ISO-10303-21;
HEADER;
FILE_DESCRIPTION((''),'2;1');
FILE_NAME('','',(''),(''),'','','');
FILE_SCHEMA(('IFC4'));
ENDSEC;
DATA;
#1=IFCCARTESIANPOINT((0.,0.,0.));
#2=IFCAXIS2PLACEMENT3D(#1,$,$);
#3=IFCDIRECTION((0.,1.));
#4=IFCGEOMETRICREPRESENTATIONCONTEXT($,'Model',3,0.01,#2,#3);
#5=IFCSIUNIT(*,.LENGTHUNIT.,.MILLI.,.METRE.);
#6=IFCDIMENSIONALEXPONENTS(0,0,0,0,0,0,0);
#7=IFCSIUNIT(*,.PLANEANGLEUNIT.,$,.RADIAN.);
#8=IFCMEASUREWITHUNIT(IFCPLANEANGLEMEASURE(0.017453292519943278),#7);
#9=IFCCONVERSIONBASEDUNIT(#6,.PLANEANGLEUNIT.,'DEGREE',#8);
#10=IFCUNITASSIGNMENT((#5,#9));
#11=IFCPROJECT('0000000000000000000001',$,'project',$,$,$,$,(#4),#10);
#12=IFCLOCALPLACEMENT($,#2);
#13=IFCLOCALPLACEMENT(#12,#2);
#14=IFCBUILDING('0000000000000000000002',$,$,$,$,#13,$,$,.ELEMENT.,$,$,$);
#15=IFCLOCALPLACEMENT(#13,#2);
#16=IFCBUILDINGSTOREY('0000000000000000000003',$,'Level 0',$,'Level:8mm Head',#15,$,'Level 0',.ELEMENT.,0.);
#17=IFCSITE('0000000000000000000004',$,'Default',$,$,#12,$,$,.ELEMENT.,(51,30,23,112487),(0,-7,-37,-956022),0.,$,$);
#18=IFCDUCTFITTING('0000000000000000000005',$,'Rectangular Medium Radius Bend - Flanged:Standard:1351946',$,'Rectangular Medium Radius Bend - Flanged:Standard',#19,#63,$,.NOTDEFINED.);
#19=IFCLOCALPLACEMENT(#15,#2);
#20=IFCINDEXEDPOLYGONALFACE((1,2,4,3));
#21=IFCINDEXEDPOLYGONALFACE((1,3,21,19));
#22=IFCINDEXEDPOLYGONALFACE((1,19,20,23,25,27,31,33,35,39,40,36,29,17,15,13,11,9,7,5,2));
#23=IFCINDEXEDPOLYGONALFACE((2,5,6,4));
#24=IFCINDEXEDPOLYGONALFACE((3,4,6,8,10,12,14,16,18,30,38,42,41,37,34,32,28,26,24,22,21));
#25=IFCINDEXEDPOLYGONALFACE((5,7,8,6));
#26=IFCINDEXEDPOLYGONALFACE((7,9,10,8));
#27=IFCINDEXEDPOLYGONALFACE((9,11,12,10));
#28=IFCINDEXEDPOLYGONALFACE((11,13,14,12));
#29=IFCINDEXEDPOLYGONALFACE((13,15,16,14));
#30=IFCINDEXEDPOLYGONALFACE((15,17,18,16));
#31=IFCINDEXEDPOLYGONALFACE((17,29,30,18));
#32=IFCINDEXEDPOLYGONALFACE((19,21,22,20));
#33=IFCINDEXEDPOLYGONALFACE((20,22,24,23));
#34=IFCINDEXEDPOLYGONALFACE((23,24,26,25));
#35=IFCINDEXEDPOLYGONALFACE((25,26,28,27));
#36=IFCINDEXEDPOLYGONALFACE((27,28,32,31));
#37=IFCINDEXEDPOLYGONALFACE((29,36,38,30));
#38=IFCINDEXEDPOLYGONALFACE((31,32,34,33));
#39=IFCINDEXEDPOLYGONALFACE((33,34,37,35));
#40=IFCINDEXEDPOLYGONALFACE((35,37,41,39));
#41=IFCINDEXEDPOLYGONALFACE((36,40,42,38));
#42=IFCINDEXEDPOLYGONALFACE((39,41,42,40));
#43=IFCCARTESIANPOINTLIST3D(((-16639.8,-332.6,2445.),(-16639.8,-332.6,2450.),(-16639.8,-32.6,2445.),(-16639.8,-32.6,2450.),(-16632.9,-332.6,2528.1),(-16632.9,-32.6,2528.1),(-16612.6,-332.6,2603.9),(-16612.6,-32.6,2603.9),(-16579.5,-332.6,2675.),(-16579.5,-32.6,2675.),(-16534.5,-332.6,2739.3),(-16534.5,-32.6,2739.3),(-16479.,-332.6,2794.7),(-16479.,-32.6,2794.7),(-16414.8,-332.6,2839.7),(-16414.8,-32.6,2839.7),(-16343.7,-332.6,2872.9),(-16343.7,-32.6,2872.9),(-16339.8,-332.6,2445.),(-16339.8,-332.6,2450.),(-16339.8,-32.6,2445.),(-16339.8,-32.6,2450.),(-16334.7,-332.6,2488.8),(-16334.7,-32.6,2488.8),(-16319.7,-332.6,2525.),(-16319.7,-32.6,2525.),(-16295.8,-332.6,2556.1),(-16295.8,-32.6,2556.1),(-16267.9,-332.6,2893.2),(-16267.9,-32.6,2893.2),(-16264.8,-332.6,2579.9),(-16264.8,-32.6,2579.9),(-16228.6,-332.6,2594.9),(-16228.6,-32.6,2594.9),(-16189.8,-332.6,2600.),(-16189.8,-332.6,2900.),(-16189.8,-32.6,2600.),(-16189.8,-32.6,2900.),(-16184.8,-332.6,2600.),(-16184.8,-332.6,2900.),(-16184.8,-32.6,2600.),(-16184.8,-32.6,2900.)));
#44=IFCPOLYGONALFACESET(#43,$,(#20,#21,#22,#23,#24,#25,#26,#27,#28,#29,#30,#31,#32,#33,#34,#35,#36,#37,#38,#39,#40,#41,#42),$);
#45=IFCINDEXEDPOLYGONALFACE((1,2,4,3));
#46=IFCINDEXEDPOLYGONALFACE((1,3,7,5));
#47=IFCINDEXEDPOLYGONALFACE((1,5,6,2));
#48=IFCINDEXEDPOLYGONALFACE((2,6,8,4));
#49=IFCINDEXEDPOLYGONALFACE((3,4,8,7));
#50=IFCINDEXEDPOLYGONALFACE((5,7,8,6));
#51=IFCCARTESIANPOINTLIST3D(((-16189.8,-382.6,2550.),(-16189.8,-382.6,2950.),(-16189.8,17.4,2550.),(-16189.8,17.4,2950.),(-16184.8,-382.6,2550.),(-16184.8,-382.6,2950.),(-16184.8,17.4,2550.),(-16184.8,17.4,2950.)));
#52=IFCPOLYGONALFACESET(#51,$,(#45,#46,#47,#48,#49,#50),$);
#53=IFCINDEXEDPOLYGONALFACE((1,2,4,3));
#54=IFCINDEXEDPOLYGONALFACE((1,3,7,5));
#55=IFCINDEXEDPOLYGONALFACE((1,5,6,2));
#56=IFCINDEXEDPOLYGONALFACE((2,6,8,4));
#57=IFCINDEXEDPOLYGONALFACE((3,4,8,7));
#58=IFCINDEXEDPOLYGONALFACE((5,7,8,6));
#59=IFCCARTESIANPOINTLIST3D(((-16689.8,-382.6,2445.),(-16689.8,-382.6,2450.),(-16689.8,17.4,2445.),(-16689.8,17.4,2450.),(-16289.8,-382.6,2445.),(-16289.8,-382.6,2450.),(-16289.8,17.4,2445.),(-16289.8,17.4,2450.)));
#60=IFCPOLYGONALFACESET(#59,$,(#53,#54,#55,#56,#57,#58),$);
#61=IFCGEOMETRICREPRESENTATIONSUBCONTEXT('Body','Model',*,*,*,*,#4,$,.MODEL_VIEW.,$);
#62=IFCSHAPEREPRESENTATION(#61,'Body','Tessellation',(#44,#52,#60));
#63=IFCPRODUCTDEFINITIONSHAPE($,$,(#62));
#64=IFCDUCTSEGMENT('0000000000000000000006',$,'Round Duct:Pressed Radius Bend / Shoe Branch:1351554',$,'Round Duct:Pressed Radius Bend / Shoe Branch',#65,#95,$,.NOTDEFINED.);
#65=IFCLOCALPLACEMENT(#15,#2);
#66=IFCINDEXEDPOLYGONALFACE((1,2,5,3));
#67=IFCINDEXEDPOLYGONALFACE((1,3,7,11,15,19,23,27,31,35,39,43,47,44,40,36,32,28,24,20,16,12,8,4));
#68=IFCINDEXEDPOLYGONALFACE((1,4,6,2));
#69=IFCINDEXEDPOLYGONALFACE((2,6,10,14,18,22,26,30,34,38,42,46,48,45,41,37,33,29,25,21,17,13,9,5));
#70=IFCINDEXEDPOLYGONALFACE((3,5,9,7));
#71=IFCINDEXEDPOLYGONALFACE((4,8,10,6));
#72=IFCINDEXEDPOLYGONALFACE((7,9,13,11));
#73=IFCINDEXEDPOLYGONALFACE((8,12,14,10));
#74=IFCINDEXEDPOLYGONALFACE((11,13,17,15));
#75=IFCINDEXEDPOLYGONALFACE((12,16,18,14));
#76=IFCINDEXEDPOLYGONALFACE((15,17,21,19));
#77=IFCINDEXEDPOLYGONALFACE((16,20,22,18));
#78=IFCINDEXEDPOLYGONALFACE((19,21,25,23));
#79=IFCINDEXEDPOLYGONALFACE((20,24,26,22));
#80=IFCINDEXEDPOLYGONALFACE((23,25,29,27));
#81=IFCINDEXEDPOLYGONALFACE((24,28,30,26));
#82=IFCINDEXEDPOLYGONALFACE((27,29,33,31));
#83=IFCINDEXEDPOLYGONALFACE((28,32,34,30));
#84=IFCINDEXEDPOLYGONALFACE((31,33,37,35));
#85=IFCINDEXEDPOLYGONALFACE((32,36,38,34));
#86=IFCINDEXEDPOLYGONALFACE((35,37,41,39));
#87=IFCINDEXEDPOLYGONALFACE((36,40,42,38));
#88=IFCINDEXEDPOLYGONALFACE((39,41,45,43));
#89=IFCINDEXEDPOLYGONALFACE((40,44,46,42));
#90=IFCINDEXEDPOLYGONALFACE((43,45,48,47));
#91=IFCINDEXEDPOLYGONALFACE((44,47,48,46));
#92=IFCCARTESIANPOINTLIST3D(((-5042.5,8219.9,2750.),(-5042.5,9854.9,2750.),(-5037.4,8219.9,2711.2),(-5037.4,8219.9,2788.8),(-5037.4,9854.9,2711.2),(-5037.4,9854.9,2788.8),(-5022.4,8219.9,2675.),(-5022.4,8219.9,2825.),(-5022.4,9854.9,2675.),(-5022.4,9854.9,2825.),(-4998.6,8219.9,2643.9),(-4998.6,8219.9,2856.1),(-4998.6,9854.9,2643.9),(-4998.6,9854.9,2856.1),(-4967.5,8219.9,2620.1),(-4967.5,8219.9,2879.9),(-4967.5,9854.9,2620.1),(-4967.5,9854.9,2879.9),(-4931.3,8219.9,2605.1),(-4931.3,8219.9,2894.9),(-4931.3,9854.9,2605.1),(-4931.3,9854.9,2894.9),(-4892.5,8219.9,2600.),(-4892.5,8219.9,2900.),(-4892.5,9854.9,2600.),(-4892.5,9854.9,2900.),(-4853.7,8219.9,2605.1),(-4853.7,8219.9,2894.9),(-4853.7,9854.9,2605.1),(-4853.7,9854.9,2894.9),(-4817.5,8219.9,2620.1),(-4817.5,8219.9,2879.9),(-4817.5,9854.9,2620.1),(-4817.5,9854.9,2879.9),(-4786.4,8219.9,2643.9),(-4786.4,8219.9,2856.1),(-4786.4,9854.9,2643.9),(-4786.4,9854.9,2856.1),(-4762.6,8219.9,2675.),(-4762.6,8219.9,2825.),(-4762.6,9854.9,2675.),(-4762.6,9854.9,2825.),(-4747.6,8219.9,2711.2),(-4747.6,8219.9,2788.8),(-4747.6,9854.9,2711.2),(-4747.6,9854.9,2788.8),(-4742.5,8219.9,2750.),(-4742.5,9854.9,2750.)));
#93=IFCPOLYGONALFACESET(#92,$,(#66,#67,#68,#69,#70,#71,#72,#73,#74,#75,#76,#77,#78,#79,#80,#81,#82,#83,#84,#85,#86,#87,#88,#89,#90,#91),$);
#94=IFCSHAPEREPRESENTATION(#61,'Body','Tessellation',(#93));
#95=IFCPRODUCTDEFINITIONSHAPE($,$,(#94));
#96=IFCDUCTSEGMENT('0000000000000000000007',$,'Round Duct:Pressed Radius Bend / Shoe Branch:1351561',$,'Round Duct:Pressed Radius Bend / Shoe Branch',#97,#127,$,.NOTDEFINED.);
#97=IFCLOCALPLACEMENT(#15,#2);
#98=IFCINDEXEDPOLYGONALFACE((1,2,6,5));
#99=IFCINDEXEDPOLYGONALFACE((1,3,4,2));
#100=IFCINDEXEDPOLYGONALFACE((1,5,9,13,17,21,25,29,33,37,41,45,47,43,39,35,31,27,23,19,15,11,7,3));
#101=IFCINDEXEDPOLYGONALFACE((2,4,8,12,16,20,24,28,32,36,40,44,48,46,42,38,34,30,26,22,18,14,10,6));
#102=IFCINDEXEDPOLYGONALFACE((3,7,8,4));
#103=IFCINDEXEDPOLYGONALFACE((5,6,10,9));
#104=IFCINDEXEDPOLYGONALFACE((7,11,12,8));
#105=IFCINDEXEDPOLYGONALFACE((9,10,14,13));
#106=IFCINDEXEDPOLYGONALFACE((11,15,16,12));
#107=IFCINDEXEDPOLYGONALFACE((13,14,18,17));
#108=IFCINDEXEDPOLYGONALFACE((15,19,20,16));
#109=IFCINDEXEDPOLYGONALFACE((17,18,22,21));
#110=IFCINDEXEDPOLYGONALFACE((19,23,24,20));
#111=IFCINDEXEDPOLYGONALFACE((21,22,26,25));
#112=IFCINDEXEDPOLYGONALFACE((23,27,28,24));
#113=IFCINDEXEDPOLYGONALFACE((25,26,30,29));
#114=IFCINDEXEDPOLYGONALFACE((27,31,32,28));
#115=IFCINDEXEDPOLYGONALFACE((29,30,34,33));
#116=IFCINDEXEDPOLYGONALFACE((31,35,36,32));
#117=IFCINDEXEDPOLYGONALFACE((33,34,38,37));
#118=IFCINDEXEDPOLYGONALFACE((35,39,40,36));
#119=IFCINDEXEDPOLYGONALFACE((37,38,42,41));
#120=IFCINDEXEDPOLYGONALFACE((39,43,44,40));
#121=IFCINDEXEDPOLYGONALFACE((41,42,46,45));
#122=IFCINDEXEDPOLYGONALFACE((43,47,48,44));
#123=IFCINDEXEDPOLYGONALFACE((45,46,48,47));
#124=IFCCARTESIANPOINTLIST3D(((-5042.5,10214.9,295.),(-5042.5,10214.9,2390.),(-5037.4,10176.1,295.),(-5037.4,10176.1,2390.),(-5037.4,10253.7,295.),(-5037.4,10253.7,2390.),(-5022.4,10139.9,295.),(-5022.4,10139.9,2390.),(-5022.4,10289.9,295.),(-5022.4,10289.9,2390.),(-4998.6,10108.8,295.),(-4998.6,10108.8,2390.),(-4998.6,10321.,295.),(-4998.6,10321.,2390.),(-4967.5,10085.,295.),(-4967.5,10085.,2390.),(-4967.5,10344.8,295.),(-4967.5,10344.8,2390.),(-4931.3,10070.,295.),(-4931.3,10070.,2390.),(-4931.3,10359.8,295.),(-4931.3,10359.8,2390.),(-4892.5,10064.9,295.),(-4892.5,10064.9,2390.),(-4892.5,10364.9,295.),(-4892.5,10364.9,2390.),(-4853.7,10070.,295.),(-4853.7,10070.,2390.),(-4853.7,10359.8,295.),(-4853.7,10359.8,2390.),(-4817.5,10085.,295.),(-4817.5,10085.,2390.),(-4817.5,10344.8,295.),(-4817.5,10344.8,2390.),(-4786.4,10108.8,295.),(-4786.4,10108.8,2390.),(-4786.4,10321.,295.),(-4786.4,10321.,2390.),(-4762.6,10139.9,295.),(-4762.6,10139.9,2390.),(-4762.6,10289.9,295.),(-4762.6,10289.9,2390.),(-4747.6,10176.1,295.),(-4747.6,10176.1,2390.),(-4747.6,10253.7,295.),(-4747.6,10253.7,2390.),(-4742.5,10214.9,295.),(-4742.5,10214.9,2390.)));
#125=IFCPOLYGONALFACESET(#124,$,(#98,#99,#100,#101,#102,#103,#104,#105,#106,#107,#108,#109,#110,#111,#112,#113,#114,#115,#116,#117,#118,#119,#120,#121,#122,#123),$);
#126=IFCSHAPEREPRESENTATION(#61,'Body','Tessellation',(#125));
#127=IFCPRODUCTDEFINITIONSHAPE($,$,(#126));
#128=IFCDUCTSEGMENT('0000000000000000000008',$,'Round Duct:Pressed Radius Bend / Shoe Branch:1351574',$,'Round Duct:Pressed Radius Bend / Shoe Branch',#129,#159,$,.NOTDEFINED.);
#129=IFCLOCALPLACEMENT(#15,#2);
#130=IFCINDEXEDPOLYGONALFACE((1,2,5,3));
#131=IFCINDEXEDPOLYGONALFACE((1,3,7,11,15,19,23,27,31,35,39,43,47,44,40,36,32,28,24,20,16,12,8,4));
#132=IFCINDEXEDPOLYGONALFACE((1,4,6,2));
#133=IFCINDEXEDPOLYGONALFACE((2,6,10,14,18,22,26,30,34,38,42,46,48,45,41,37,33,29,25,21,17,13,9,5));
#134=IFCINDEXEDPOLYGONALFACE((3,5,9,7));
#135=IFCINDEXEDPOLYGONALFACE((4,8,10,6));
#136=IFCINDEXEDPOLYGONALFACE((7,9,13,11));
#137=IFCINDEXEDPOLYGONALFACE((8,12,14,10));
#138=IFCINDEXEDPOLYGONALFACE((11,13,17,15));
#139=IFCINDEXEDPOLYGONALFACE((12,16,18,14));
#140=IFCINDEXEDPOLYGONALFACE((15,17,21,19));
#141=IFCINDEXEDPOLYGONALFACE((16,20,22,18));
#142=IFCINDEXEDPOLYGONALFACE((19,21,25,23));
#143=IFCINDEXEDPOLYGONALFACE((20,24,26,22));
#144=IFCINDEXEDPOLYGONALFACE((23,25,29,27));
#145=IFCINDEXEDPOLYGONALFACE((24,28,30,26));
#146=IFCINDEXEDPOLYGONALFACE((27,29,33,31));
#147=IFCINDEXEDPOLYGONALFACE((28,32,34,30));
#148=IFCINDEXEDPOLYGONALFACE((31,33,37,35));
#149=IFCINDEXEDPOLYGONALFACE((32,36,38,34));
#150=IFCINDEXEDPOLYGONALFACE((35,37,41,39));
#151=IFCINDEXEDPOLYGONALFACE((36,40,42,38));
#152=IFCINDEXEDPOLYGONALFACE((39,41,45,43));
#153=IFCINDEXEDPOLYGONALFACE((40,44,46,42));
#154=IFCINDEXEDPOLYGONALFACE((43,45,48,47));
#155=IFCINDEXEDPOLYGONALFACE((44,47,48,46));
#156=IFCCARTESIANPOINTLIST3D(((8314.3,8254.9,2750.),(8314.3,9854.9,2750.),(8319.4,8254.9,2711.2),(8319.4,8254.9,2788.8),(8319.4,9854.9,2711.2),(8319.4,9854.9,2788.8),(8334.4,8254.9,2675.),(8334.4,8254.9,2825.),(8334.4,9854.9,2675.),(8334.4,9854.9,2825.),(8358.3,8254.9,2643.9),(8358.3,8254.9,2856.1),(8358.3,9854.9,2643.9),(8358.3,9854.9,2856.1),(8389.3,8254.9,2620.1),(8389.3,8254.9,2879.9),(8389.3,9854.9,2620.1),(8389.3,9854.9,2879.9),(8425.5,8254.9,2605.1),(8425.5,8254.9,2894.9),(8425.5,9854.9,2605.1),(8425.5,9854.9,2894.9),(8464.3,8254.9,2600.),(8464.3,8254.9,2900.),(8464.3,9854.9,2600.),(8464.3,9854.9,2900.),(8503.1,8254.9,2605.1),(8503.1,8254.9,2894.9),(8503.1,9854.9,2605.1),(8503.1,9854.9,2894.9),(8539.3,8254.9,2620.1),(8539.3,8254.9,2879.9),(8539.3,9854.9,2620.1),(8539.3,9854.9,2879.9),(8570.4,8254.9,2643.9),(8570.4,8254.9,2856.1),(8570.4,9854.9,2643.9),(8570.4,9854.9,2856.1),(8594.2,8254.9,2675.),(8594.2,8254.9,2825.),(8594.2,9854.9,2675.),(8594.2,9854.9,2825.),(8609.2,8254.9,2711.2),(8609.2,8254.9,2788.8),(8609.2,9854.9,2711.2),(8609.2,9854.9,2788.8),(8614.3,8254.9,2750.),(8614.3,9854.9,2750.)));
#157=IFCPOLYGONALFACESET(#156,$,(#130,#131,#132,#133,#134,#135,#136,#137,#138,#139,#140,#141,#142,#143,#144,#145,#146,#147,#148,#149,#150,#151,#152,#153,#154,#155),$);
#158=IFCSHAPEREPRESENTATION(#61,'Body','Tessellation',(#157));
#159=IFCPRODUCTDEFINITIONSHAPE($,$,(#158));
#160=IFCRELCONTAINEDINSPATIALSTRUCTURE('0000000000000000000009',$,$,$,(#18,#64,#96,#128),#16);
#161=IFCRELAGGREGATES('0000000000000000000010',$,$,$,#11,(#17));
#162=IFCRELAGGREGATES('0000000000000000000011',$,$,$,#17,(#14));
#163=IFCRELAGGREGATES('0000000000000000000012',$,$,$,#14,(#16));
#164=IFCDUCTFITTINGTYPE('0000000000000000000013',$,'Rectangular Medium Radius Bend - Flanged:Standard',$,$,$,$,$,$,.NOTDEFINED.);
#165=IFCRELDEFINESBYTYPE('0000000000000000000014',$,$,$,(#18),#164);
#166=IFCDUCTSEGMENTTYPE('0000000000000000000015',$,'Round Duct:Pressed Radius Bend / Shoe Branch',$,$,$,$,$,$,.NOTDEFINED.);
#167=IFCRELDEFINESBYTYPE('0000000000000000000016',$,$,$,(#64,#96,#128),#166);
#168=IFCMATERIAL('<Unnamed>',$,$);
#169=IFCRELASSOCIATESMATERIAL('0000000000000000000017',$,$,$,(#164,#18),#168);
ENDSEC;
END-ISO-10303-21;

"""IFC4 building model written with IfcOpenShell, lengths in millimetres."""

from ifc_helpers import new_model, entity, si_unit, converted_unit, direction, frame, origin, place, context, subcontext, project, spatial, line, arc, indexed_curve, outline, extrude, source, transform, mapped, material, type_object, type_shapes, element, save


model = new_model("IFC4")

# Units and contexts
model_context = context("Model", 3, precision=0.01, world=origin(), true_north=direction((0.0, 1.0)))
body_context = subcontext(model_context, "Body", "Model", "MODEL_VIEW")
ifc_project = project(units=[si_unit("LENGTHUNIT", "METRE", prefix="MILLI"), converted_unit("PLANEANGLEUNIT", "DEGREE", entity("IfcPlaneAngleMeasure", 0.017453292519943278), si_unit("PLANEANGLEUNIT", "RADIAN"), dimensions=[0, 0, 0, 0, 0, 0, 0])], contexts=[model_context])

# Site, building, storey
site_placement = place(None, origin())
site = spatial("IfcSite", under=ifc_project, at=site_placement, Name="Default", CompositionType="ELEMENT", RefLatitude=(51, 30, 23, 112487), RefLongitude=(0, -7, -37, -956022), RefElevation=0.0)
building_placement = place(site_placement, origin())
building = spatial("IfcBuilding", under=site, at=building_placement, CompositionType="ELEMENT")
storey_placement = place(building_placement, origin())
storey = spatial("IfcBuildingStorey", under=building, at=storey_placement, Name="Level 0", ObjectType="Level:8mm Head", LongName="Level 0", CompositionType="ELEMENT", Elevation=0.0)

# Duct fitting
ifc_material = material(Name="<Unnamed>")
duct_fitting_type = type_object("IfcDuctFittingType", Name="Rectangular Medium Radius Bend - Flanged:Standard", PredefinedType="NOTDEFINED", material=ifc_material)
shared_shape = source(origin(), body_context, "Body", "SweptSolid", [
    extrude(outline(indexed_curve([(-153.8, -301.2), (-148.7, -301.2), (169.4, -169.4), (301.3, 148.7), (301.3, 153.7), (1.3, 153.7), (1.3, 148.8), (-42.7, 42.7), (-148.7, -1.2), (-153.8, -1.2)], segments=[line(1, 2), arc(2, 3, 4), line(4, 5, 6, 7), arc(7, 8, 9), line(9, 10, 1)], self_intersect=False)), frame((-151.2, 151.2, -150.0)), (0.0, 0.0, 1.0), 300.0),
    extrude(outline(indexed_curve([(-2.5, -200.0), (2.5, -200.0), (2.5, 200.0), (-2.5, 200.0), (-2.5, -200.0)], self_intersect=False)), frame((0.0, 302.5, -200.0), z_axis=(0.0, 0.0, 1.0), x_axis=(0.0, 1.0, 0.0)), (0.0, 0.0, 1.0), 400.0),
    extrude(outline(indexed_curve([(-2.5, -200.0), (2.5, -200.0), (2.5, 200.0), (-2.5, 200.0), (-2.5, -200.0)], self_intersect=False)), frame((-302.5, 0.0, -200.0)), (0.0, 0.0, 1.0), 400.0),
])
type_shapes(duct_fitting_type, [shared_shape])
for number, where, z_axis, x_axis, name in (
    (1, (-16489.8, -182.6, 2750.0), (0.0, 1.0, 0.0), (0.0, 0.0, 1.0), "Rectangular Medium Radius Bend - Flanged:Standard:1351946"),
):
    element("IfcDuctFitting", number, at=place(storey_placement, frame(where, z_axis=z_axis, x_axis=x_axis)), inside=storey, type_object=duct_fitting_type, material=ifc_material, Name=name, ObjectType="Rectangular Medium Radius Bend - Flanged:Standard", PredefinedType="NOTDEFINED", context=body_context, shape_type="MappedRepresentation", body=[
        mapped(shared_shape, transform((0.0, 0.0, 0.0), scale=1.0)),
    ])

# Duct segments
duct_segment_type_1 = type_object("IfcDuctSegmentType", Name="Round Duct:Pressed Radius Bend / Shoe Branch", PredefinedType="NOTDEFINED")
duct_segment_1_placement = place(storey_placement, origin())
element("IfcDuctSegment", 2, at=duct_segment_1_placement, inside=storey, type_object=duct_segment_type_1, Name="Round Duct:Pressed Radius Bend / Shoe Branch:1351554", ObjectType="Round Duct:Pressed Radius Bend / Shoe Branch", PredefinedType="NOTDEFINED", context=body_context, shape_type="SweptSolid", body=[
    extrude(outline(indexed_curve([(150.0, 0.0), (106.1, 106.1), (0.0, 150.0), (-106.1, 106.1), (-150.0, 0.0), (-106.1, -106.1), (0.0, -150.0), (106.1, -106.1)], segments=[arc(1, 2, 3), arc(3, 4, 5), arc(5, 6, 7), arc(7, 8, 1)], self_intersect=False)), frame((-4892.5, 8219.9, 2750.0), z_axis=(0.0, 1.0, 0.0), x_axis=(1.0, 0.0, 0.0)), (0.0, 0.0, 1.0), 1635.0),
])
duct_segment_2_placement = place(storey_placement, origin())
element("IfcDuctSegment", 3, at=duct_segment_2_placement, inside=storey, type_object=duct_segment_type_1, Name="Round Duct:Pressed Radius Bend / Shoe Branch:1351561", ObjectType="Round Duct:Pressed Radius Bend / Shoe Branch", PredefinedType="NOTDEFINED", context=body_context, shape_type="SweptSolid", body=[
    extrude(outline(indexed_curve([(150.0, 0.0), (106.1, 106.1), (0.0, 150.0), (-106.1, 106.1), (-150.0, 0.0), (-106.1, -106.1), (0.0, -150.0), (106.1, -106.1)], segments=[arc(1, 2, 3), arc(3, 4, 5), arc(5, 6, 7), arc(7, 8, 1)], self_intersect=False)), frame((-4892.5, 10214.9, 295.0)), (0.0, 0.0, 1.0), 2095.0),
])
duct_segment_3_placement = place(storey_placement, origin())
element("IfcDuctSegment", 4, at=duct_segment_3_placement, inside=storey, type_object=duct_segment_type_1, Name="Round Duct:Pressed Radius Bend / Shoe Branch:1351574", ObjectType="Round Duct:Pressed Radius Bend / Shoe Branch", PredefinedType="NOTDEFINED", context=body_context, shape_type="SweptSolid", body=[
    extrude(outline(indexed_curve([(150.0, 0.0), (106.1, 106.1), (0.0, 150.0), (-106.1, 106.1), (-150.0, 0.0), (-106.1, -106.1), (0.0, -150.0), (106.1, -106.1)], segments=[arc(1, 2, 3), arc(3, 4, 5), arc(5, 6, 7), arc(7, 8, 1)], self_intersect=False)), frame((8464.3, 8254.9, 2750.0), z_axis=(0.0, 1.0, 0.0), x_axis=(-1.0, 0.0, 0.0)), (0.0, 0.0, 1.0), 1600.0),
])

save(model, "model.ifc")
